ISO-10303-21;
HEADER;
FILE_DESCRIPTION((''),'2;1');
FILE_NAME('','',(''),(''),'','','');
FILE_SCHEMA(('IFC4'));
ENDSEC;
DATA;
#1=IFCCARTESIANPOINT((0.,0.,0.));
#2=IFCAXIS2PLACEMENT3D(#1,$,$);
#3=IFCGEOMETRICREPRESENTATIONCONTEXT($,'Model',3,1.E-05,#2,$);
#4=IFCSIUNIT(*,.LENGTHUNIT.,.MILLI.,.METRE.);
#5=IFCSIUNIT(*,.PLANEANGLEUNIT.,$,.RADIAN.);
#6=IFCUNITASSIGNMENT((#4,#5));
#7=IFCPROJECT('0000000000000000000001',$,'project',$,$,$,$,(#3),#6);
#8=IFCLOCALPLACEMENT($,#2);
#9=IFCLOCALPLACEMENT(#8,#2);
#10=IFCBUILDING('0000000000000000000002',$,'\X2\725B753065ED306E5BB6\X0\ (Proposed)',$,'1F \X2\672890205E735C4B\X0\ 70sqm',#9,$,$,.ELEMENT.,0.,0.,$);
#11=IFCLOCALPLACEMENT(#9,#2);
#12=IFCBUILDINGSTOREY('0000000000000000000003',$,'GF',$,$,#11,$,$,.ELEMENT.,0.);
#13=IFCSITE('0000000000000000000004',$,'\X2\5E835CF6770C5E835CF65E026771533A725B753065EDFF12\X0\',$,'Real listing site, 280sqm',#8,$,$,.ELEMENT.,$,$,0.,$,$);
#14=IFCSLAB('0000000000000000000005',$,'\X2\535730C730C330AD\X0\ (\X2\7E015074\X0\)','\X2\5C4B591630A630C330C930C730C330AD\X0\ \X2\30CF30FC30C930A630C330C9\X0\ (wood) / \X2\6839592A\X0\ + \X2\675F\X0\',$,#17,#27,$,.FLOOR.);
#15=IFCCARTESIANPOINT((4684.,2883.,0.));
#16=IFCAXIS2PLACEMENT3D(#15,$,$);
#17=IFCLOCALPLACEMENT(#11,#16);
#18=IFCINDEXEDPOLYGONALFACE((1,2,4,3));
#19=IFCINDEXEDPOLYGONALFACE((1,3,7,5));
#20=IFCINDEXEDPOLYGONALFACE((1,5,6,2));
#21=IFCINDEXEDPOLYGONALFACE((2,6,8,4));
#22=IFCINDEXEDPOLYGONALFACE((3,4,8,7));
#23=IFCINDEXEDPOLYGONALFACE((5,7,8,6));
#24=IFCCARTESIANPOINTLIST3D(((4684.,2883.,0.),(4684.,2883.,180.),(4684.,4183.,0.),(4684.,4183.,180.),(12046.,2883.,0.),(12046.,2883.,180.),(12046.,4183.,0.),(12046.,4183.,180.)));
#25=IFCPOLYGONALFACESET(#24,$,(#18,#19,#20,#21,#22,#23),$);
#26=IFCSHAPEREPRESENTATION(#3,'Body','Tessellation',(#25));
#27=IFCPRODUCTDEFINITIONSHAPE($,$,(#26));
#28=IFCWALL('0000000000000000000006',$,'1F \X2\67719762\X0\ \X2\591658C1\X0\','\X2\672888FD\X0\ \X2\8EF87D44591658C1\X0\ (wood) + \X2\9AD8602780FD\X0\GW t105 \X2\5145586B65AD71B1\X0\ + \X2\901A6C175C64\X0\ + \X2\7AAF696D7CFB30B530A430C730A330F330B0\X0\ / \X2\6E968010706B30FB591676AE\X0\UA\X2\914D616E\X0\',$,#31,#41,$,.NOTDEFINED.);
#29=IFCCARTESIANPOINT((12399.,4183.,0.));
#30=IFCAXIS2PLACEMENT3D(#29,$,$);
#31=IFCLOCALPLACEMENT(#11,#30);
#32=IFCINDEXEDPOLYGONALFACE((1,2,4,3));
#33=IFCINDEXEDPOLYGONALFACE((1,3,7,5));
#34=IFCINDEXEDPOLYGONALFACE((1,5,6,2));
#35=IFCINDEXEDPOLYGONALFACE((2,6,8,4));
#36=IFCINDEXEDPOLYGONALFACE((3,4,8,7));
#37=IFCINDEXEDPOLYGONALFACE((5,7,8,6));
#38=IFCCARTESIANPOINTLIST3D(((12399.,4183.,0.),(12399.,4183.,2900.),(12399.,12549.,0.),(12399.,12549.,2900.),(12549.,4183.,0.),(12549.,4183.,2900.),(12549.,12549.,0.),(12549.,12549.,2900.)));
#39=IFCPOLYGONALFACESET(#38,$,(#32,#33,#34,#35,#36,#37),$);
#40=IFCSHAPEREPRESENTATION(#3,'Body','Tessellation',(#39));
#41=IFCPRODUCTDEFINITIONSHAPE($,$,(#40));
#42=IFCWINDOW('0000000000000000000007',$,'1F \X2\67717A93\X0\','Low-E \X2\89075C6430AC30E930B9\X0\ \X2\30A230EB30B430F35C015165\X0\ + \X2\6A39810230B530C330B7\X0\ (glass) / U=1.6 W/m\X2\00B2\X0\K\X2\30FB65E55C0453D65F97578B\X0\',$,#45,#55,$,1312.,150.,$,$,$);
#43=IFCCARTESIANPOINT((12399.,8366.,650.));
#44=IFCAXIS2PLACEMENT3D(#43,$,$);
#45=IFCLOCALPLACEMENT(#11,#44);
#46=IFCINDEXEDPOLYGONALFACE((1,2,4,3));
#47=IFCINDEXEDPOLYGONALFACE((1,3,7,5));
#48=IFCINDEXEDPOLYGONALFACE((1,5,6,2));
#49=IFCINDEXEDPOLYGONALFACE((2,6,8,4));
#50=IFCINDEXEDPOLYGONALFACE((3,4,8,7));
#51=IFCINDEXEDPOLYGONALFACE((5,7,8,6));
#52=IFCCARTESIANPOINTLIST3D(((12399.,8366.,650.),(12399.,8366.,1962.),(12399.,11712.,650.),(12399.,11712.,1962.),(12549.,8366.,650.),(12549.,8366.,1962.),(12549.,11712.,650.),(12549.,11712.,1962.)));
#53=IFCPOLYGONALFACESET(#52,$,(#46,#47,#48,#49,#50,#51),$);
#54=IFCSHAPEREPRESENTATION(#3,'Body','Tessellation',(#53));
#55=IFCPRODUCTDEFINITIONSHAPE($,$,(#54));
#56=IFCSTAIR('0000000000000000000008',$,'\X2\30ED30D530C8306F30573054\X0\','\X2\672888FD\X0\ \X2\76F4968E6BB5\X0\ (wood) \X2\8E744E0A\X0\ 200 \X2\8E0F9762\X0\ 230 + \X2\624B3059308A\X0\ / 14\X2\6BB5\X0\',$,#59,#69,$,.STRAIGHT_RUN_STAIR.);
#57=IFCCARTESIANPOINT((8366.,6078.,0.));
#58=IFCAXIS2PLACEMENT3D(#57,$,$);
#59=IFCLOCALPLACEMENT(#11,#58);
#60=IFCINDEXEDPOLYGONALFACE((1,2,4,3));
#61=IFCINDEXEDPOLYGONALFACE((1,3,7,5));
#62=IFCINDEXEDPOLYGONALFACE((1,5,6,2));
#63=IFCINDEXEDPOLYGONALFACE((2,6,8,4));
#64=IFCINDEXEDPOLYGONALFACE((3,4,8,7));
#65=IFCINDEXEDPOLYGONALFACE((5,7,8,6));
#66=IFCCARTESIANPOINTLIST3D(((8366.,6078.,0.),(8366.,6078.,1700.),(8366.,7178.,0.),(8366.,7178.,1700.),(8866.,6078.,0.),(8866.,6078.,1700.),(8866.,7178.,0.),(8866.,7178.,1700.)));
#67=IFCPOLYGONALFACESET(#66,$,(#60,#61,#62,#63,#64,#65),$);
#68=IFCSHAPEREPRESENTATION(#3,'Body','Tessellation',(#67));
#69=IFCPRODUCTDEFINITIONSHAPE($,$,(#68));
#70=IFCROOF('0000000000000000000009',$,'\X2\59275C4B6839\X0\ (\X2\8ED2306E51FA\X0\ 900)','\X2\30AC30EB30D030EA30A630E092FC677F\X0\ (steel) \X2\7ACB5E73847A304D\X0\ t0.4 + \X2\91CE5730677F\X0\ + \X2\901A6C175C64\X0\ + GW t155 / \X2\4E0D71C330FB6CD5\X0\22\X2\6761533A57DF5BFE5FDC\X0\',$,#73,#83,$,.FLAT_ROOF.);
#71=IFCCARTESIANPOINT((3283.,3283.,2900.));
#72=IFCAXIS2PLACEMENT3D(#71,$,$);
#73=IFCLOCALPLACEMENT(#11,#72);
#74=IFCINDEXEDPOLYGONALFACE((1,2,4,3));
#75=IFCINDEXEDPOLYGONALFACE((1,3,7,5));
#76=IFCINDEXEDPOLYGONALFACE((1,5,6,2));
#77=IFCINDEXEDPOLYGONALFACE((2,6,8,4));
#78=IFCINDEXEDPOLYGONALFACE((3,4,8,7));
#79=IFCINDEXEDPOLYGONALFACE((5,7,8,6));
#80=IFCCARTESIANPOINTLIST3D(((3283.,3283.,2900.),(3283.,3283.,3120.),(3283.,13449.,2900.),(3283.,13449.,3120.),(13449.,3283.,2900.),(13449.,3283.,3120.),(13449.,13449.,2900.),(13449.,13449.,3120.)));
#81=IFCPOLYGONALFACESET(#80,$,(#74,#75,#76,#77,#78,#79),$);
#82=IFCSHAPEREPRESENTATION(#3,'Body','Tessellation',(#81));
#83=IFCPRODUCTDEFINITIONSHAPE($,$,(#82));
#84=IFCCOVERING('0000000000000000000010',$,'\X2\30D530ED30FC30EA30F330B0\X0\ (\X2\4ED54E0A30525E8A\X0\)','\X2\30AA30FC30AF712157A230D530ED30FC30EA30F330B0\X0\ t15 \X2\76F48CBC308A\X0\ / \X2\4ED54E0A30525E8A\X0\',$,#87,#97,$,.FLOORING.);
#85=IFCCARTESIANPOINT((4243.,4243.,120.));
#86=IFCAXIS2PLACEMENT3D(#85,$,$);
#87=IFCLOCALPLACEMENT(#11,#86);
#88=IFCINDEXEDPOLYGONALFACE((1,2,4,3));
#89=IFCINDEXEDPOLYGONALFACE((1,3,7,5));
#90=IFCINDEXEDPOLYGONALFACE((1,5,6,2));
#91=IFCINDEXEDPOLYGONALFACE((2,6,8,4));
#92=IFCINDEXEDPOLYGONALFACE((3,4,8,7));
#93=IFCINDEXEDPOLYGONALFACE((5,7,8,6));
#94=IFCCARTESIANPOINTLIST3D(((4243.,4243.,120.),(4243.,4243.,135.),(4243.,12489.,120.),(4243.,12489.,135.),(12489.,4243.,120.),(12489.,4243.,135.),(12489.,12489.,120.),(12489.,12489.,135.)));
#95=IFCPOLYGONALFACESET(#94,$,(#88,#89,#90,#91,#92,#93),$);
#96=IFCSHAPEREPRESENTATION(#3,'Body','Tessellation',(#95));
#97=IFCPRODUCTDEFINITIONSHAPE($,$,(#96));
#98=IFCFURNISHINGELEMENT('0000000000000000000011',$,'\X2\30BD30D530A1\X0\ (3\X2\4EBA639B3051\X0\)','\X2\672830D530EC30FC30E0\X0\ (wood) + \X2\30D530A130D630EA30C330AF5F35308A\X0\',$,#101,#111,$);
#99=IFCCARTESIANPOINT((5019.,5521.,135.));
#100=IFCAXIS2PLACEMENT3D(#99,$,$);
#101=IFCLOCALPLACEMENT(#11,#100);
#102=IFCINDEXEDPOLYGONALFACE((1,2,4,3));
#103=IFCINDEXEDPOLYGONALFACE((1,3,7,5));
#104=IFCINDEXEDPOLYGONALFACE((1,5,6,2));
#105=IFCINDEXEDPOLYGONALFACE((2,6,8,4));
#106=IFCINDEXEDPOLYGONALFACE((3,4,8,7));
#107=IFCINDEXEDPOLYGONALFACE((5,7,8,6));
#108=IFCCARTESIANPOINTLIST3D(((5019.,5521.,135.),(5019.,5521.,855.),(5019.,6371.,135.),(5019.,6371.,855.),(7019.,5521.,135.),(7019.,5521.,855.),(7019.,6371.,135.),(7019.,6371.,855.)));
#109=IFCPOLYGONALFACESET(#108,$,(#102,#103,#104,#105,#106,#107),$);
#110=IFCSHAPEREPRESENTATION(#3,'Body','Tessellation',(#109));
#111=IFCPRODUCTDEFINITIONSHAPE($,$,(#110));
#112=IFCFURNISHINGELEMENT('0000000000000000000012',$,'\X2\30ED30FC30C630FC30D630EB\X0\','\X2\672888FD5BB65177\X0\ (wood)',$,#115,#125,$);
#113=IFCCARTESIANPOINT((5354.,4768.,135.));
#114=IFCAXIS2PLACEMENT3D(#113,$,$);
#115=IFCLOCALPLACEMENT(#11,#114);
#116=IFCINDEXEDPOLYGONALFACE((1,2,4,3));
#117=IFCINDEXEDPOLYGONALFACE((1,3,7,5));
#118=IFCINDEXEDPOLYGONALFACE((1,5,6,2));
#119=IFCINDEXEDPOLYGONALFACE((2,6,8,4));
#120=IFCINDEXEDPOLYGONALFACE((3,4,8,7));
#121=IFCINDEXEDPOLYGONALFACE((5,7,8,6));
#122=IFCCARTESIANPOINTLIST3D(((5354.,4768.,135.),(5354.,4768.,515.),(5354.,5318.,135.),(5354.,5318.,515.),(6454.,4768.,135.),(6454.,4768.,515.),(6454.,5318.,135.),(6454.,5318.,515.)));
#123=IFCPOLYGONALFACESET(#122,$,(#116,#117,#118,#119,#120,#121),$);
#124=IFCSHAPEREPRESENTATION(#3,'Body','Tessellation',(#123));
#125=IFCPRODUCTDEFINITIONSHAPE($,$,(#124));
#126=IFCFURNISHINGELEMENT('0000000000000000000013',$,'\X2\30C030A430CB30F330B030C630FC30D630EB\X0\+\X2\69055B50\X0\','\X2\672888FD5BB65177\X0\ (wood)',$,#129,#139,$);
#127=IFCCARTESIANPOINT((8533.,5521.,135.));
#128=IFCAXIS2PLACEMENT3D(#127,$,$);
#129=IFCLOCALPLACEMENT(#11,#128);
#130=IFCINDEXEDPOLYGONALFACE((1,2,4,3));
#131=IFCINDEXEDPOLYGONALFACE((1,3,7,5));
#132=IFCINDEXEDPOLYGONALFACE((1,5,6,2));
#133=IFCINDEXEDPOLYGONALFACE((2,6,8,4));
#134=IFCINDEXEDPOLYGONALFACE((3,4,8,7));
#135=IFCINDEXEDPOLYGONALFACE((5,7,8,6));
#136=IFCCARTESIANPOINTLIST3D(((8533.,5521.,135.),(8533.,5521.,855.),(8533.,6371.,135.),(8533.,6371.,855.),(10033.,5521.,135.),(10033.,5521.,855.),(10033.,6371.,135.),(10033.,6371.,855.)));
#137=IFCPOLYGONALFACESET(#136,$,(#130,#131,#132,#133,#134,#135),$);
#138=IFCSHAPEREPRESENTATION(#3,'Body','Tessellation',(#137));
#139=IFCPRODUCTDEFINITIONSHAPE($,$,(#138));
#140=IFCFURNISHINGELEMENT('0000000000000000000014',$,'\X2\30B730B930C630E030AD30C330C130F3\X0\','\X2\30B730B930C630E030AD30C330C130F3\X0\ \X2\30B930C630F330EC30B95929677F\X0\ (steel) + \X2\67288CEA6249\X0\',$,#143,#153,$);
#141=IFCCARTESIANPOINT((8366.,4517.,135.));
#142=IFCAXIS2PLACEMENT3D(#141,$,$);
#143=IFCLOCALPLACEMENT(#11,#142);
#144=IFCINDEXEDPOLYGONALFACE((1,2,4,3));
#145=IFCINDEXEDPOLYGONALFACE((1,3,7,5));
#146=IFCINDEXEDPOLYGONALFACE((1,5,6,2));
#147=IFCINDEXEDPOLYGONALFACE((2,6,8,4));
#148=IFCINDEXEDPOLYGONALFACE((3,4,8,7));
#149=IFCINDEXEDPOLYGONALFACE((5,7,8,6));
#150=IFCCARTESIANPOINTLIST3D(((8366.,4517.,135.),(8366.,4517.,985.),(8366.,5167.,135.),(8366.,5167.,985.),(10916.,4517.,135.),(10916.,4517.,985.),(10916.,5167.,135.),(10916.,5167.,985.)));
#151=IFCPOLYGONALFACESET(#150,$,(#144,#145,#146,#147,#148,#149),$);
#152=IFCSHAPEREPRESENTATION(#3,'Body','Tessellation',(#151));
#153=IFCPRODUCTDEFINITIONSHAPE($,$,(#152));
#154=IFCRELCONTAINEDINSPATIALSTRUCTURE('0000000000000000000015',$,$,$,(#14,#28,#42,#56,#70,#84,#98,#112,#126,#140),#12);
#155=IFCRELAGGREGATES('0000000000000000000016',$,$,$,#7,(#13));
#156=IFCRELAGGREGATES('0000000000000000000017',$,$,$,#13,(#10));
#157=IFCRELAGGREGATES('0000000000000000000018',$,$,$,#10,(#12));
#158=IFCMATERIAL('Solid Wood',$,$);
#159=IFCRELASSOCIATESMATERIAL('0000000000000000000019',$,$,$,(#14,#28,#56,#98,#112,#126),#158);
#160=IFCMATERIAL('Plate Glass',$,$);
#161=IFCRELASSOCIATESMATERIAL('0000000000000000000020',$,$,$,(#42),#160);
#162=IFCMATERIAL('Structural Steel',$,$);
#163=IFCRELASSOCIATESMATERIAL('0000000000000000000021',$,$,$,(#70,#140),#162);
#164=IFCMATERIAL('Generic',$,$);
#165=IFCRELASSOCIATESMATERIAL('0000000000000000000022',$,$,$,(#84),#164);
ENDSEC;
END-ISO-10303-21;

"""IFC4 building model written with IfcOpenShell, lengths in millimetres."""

from ifc_helpers import new_model, si_unit, frame, frame_2d, origin, place, context, project, spatial, rectangle, extrude, material, element, fill, save


model = new_model("IFC4")

# Units and contexts
model_context = context("Model", 3, precision=1e-05, world=origin())
ifc_project = project(units=[si_unit("LENGTHUNIT", "METRE", prefix="MILLI"), si_unit("PLANEANGLEUNIT", "RADIAN")], contexts=[model_context])

# Site, building, storey
site_placement = place(None, origin())
site = spatial("IfcSite", under=ifc_project, at=site_placement, Name="広島県広島市東区牛田旭２", ObjectType="Real listing site, 280sqm", CompositionType="ELEMENT", RefElevation=0.0)
building_placement = place(site_placement, origin())
building = spatial("IfcBuilding", under=site, at=building_placement, Name="牛田旭の家 (Proposed)", ObjectType="1F 木造平屋 70sqm", CompositionType="ELEMENT", ElevationOfRefHeight=0.0, ElevationOfTerrain=0.0)
storey_placement = place(building_placement, origin())
storey = spatial("IfcBuildingStorey", under=building, at=storey_placement, Name="GF", CompositionType="ELEMENT", Elevation=0.0)

# Slab
ifc_material_1 = material(Name="Solid Wood")
slab_1_placement = place(storey_placement, frame((4684.0, 2883.0, 0.0)))
element("IfcSlab", 1, at=slab_1_placement, inside=storey, material=ifc_material_1, Name="南デッキ (縁側)", Description="屋外ウッドデッキ ハードウッド (wood) / 根太 + 束", PredefinedType="FLOOR", context=model_context, shape_type="SweptSolid", body=[
    extrude(rectangle(XDim=7362.0, YDim=1300.0, at=frame_2d((3681.0, 650.0))), frame((4684.0, 2883.0, 0.0)), (0.0, 0.0, 1.0), 180.0),
])

# Shared definitions
ifc_material_2 = material(Name="Plate Glass")

# Wall, opening, window
wall_1_placement = place(storey_placement, frame((12399.0, 4183.0, 0.0)))
wall_1 = element("IfcWall", 2, at=wall_1_placement, inside=storey, material=ifc_material_1, Name="1F 東面 外壁", Description="木製 軸組外壁 (wood) + 高性能GW t105 充填断熱 + 通気層 + 窯業系サイディング / 準耐火・外皮UA配慮", PredefinedType="NOTDEFINED", context=model_context, shape_type="SweptSolid", body=[
    extrude(rectangle(XDim=150.0, YDim=8366.0, at=frame_2d((75.0, 4183.0))), frame((12399.0, 4183.0, 0.0)), (0.0, 0.0, 1.0), 2900.0),
])
opening_1_placement = place(storey_placement, frame((12399.0, 8366.0, 650.0)))
opening_1 = element("IfcOpeningElement", 3, at=opening_1_placement, cuts=wall_1, PredefinedType="NOTDEFINED", context=model_context, shape_type="SweptSolid", body=[
    extrude(rectangle(XDim=150.0, YDim=3346.0, at=frame_2d((75.0, 1673.0))), frame((12399.0, 8366.0, 650.0)), (0.0, 0.0, 1.0), 1312.0),
])
window_1_placement = place(storey_placement, frame((12399.0, 8366.0, 650.0)))
window_1 = element("IfcWindow", 4, at=window_1_placement, inside=storey, material=ifc_material_2, Name="1F 東窓", Description="Low-E 複層ガラス アルゴン封入 + 樹脂サッシ (glass) / U=1.6 W/m²K・日射取得型", OverallHeight=1312.0, OverallWidth=150.0, context=model_context, shape_type="SweptSolid", body=[
    extrude(rectangle(XDim=150.0, YDim=3346.0, at=frame_2d((75.0, 1673.0))), frame((12399.0, 8366.0, 650.0)), (0.0, 0.0, 1.0), 1312.0),
])
fill(opening_1, window_1)

# Stair
stair_placement = place(storey_placement, frame((8366.0, 6078.0, 0.0)))
element("IfcStair", 5, at=stair_placement, inside=storey, material=ifc_material_1, Name="ロフトはしご", Description="木製 直階段 (wood) 蹴上 200 踏面 230 + 手すり / 14段", PredefinedType="STRAIGHT_RUN_STAIR", context=model_context, shape_type="SweptSolid", body=[
    extrude(rectangle(XDim=500.0, YDim=1100.0, at=frame_2d((250.0, 550.0))), frame((8366.0, 6078.0, 0.0)), (0.0, 0.0, 1.0), 1700.0),
])

# Roof
ifc_material_3 = material(Name="Structural Steel")
roof_placement = place(storey_placement, frame((3283.0, 3283.0, 2900.0)))
element("IfcRoof", 6, at=roof_placement, inside=storey, material=ifc_material_3, Name="大屋根 (軒の出 900)", Description="ガルバリウム鋼板 (steel) 立平葺き t0.4 + 野地板 + 通気層 + GW t155 / 不燃・法22条区域対応", PredefinedType="FLAT_ROOF", context=model_context, shape_type="SweptSolid", body=[
    extrude(rectangle(XDim=10166.0, YDim=10166.0, at=frame_2d((5083.0, 5083.0))), frame((3283.0, 3283.0, 2900.0)), (0.0, 0.0, 1.0), 220.0),
])

# Covering
ifc_material_4 = material(Name="Generic")
covering_placement = place(storey_placement, frame((4243.0, 4243.0, 120.0)))
element("IfcCovering", 7, at=covering_placement, inside=storey, material=ifc_material_4, Name="フローリング (仕上げ床)", Description="オーク無垢フローリング t15 直貼り / 仕上げ床", PredefinedType="FLOORING", context=model_context, shape_type="SweptSolid", body=[
    extrude(rectangle(XDim=8246.0, YDim=8246.0, at=frame_2d((4123.0, 4123.0))), frame((4243.0, 4243.0, 120.0)), (0.0, 0.0, 1.0), 15.0),
])

# Furnishing elements
furnishing_1_placement = place(storey_placement, frame((5019.0, 5521.0, 135.0)))
element("IfcFurnishingElement", 8, at=furnishing_1_placement, inside=storey, material=ifc_material_1, Name="ソファ (3人掛け)", Description="木フレーム (wood) + ファブリック張り", context=model_context, shape_type="SweptSolid", body=[
    extrude(rectangle(XDim=2000.0, YDim=850.0, at=frame_2d((1000.0, 425.0))), frame((5019.0, 5521.0, 135.0)), (0.0, 0.0, 1.0), 720.0),
])
furnishing_2_placement = place(storey_placement, frame((5354.0, 4768.0, 135.0)))
element("IfcFurnishingElement", 9, at=furnishing_2_placement, inside=storey, material=ifc_material_1, Name="ローテーブル", Description="木製家具 (wood)", context=model_context, shape_type="SweptSolid", body=[
    extrude(rectangle(XDim=1100.0, YDim=550.0, at=frame_2d((550.0, 275.0))), frame((5354.0, 4768.0, 135.0)), (0.0, 0.0, 1.0), 380.0),
])
furnishing_3_placement = place(storey_placement, frame((8533.0, 5521.0, 135.0)))
element("IfcFurnishingElement", 10, at=furnishing_3_placement, inside=storey, material=ifc_material_1, Name="ダイニングテーブル+椅子", Description="木製家具 (wood)", context=model_context, shape_type="SweptSolid", body=[
    extrude(rectangle(XDim=1500.0, YDim=850.0, at=frame_2d((750.0, 425.0))), frame((8533.0, 5521.0, 135.0)), (0.0, 0.0, 1.0), 720.0),
])
furnishing_4_placement = place(storey_placement, frame((8366.0, 4517.0, 135.0)))
element("IfcFurnishingElement", 11, at=furnishing_4_placement, inside=storey, material=ifc_material_3, Name="システムキッチン", Description="システムキッチン ステンレス天板 (steel) + 木質扉", context=model_context, shape_type="SweptSolid", body=[
    extrude(rectangle(XDim=2550.0, YDim=650.0, at=frame_2d((1275.0, 325.0))), frame((8366.0, 4517.0, 135.0)), (0.0, 0.0, 1.0), 850.0),
])

save(model, "model.ifc")
